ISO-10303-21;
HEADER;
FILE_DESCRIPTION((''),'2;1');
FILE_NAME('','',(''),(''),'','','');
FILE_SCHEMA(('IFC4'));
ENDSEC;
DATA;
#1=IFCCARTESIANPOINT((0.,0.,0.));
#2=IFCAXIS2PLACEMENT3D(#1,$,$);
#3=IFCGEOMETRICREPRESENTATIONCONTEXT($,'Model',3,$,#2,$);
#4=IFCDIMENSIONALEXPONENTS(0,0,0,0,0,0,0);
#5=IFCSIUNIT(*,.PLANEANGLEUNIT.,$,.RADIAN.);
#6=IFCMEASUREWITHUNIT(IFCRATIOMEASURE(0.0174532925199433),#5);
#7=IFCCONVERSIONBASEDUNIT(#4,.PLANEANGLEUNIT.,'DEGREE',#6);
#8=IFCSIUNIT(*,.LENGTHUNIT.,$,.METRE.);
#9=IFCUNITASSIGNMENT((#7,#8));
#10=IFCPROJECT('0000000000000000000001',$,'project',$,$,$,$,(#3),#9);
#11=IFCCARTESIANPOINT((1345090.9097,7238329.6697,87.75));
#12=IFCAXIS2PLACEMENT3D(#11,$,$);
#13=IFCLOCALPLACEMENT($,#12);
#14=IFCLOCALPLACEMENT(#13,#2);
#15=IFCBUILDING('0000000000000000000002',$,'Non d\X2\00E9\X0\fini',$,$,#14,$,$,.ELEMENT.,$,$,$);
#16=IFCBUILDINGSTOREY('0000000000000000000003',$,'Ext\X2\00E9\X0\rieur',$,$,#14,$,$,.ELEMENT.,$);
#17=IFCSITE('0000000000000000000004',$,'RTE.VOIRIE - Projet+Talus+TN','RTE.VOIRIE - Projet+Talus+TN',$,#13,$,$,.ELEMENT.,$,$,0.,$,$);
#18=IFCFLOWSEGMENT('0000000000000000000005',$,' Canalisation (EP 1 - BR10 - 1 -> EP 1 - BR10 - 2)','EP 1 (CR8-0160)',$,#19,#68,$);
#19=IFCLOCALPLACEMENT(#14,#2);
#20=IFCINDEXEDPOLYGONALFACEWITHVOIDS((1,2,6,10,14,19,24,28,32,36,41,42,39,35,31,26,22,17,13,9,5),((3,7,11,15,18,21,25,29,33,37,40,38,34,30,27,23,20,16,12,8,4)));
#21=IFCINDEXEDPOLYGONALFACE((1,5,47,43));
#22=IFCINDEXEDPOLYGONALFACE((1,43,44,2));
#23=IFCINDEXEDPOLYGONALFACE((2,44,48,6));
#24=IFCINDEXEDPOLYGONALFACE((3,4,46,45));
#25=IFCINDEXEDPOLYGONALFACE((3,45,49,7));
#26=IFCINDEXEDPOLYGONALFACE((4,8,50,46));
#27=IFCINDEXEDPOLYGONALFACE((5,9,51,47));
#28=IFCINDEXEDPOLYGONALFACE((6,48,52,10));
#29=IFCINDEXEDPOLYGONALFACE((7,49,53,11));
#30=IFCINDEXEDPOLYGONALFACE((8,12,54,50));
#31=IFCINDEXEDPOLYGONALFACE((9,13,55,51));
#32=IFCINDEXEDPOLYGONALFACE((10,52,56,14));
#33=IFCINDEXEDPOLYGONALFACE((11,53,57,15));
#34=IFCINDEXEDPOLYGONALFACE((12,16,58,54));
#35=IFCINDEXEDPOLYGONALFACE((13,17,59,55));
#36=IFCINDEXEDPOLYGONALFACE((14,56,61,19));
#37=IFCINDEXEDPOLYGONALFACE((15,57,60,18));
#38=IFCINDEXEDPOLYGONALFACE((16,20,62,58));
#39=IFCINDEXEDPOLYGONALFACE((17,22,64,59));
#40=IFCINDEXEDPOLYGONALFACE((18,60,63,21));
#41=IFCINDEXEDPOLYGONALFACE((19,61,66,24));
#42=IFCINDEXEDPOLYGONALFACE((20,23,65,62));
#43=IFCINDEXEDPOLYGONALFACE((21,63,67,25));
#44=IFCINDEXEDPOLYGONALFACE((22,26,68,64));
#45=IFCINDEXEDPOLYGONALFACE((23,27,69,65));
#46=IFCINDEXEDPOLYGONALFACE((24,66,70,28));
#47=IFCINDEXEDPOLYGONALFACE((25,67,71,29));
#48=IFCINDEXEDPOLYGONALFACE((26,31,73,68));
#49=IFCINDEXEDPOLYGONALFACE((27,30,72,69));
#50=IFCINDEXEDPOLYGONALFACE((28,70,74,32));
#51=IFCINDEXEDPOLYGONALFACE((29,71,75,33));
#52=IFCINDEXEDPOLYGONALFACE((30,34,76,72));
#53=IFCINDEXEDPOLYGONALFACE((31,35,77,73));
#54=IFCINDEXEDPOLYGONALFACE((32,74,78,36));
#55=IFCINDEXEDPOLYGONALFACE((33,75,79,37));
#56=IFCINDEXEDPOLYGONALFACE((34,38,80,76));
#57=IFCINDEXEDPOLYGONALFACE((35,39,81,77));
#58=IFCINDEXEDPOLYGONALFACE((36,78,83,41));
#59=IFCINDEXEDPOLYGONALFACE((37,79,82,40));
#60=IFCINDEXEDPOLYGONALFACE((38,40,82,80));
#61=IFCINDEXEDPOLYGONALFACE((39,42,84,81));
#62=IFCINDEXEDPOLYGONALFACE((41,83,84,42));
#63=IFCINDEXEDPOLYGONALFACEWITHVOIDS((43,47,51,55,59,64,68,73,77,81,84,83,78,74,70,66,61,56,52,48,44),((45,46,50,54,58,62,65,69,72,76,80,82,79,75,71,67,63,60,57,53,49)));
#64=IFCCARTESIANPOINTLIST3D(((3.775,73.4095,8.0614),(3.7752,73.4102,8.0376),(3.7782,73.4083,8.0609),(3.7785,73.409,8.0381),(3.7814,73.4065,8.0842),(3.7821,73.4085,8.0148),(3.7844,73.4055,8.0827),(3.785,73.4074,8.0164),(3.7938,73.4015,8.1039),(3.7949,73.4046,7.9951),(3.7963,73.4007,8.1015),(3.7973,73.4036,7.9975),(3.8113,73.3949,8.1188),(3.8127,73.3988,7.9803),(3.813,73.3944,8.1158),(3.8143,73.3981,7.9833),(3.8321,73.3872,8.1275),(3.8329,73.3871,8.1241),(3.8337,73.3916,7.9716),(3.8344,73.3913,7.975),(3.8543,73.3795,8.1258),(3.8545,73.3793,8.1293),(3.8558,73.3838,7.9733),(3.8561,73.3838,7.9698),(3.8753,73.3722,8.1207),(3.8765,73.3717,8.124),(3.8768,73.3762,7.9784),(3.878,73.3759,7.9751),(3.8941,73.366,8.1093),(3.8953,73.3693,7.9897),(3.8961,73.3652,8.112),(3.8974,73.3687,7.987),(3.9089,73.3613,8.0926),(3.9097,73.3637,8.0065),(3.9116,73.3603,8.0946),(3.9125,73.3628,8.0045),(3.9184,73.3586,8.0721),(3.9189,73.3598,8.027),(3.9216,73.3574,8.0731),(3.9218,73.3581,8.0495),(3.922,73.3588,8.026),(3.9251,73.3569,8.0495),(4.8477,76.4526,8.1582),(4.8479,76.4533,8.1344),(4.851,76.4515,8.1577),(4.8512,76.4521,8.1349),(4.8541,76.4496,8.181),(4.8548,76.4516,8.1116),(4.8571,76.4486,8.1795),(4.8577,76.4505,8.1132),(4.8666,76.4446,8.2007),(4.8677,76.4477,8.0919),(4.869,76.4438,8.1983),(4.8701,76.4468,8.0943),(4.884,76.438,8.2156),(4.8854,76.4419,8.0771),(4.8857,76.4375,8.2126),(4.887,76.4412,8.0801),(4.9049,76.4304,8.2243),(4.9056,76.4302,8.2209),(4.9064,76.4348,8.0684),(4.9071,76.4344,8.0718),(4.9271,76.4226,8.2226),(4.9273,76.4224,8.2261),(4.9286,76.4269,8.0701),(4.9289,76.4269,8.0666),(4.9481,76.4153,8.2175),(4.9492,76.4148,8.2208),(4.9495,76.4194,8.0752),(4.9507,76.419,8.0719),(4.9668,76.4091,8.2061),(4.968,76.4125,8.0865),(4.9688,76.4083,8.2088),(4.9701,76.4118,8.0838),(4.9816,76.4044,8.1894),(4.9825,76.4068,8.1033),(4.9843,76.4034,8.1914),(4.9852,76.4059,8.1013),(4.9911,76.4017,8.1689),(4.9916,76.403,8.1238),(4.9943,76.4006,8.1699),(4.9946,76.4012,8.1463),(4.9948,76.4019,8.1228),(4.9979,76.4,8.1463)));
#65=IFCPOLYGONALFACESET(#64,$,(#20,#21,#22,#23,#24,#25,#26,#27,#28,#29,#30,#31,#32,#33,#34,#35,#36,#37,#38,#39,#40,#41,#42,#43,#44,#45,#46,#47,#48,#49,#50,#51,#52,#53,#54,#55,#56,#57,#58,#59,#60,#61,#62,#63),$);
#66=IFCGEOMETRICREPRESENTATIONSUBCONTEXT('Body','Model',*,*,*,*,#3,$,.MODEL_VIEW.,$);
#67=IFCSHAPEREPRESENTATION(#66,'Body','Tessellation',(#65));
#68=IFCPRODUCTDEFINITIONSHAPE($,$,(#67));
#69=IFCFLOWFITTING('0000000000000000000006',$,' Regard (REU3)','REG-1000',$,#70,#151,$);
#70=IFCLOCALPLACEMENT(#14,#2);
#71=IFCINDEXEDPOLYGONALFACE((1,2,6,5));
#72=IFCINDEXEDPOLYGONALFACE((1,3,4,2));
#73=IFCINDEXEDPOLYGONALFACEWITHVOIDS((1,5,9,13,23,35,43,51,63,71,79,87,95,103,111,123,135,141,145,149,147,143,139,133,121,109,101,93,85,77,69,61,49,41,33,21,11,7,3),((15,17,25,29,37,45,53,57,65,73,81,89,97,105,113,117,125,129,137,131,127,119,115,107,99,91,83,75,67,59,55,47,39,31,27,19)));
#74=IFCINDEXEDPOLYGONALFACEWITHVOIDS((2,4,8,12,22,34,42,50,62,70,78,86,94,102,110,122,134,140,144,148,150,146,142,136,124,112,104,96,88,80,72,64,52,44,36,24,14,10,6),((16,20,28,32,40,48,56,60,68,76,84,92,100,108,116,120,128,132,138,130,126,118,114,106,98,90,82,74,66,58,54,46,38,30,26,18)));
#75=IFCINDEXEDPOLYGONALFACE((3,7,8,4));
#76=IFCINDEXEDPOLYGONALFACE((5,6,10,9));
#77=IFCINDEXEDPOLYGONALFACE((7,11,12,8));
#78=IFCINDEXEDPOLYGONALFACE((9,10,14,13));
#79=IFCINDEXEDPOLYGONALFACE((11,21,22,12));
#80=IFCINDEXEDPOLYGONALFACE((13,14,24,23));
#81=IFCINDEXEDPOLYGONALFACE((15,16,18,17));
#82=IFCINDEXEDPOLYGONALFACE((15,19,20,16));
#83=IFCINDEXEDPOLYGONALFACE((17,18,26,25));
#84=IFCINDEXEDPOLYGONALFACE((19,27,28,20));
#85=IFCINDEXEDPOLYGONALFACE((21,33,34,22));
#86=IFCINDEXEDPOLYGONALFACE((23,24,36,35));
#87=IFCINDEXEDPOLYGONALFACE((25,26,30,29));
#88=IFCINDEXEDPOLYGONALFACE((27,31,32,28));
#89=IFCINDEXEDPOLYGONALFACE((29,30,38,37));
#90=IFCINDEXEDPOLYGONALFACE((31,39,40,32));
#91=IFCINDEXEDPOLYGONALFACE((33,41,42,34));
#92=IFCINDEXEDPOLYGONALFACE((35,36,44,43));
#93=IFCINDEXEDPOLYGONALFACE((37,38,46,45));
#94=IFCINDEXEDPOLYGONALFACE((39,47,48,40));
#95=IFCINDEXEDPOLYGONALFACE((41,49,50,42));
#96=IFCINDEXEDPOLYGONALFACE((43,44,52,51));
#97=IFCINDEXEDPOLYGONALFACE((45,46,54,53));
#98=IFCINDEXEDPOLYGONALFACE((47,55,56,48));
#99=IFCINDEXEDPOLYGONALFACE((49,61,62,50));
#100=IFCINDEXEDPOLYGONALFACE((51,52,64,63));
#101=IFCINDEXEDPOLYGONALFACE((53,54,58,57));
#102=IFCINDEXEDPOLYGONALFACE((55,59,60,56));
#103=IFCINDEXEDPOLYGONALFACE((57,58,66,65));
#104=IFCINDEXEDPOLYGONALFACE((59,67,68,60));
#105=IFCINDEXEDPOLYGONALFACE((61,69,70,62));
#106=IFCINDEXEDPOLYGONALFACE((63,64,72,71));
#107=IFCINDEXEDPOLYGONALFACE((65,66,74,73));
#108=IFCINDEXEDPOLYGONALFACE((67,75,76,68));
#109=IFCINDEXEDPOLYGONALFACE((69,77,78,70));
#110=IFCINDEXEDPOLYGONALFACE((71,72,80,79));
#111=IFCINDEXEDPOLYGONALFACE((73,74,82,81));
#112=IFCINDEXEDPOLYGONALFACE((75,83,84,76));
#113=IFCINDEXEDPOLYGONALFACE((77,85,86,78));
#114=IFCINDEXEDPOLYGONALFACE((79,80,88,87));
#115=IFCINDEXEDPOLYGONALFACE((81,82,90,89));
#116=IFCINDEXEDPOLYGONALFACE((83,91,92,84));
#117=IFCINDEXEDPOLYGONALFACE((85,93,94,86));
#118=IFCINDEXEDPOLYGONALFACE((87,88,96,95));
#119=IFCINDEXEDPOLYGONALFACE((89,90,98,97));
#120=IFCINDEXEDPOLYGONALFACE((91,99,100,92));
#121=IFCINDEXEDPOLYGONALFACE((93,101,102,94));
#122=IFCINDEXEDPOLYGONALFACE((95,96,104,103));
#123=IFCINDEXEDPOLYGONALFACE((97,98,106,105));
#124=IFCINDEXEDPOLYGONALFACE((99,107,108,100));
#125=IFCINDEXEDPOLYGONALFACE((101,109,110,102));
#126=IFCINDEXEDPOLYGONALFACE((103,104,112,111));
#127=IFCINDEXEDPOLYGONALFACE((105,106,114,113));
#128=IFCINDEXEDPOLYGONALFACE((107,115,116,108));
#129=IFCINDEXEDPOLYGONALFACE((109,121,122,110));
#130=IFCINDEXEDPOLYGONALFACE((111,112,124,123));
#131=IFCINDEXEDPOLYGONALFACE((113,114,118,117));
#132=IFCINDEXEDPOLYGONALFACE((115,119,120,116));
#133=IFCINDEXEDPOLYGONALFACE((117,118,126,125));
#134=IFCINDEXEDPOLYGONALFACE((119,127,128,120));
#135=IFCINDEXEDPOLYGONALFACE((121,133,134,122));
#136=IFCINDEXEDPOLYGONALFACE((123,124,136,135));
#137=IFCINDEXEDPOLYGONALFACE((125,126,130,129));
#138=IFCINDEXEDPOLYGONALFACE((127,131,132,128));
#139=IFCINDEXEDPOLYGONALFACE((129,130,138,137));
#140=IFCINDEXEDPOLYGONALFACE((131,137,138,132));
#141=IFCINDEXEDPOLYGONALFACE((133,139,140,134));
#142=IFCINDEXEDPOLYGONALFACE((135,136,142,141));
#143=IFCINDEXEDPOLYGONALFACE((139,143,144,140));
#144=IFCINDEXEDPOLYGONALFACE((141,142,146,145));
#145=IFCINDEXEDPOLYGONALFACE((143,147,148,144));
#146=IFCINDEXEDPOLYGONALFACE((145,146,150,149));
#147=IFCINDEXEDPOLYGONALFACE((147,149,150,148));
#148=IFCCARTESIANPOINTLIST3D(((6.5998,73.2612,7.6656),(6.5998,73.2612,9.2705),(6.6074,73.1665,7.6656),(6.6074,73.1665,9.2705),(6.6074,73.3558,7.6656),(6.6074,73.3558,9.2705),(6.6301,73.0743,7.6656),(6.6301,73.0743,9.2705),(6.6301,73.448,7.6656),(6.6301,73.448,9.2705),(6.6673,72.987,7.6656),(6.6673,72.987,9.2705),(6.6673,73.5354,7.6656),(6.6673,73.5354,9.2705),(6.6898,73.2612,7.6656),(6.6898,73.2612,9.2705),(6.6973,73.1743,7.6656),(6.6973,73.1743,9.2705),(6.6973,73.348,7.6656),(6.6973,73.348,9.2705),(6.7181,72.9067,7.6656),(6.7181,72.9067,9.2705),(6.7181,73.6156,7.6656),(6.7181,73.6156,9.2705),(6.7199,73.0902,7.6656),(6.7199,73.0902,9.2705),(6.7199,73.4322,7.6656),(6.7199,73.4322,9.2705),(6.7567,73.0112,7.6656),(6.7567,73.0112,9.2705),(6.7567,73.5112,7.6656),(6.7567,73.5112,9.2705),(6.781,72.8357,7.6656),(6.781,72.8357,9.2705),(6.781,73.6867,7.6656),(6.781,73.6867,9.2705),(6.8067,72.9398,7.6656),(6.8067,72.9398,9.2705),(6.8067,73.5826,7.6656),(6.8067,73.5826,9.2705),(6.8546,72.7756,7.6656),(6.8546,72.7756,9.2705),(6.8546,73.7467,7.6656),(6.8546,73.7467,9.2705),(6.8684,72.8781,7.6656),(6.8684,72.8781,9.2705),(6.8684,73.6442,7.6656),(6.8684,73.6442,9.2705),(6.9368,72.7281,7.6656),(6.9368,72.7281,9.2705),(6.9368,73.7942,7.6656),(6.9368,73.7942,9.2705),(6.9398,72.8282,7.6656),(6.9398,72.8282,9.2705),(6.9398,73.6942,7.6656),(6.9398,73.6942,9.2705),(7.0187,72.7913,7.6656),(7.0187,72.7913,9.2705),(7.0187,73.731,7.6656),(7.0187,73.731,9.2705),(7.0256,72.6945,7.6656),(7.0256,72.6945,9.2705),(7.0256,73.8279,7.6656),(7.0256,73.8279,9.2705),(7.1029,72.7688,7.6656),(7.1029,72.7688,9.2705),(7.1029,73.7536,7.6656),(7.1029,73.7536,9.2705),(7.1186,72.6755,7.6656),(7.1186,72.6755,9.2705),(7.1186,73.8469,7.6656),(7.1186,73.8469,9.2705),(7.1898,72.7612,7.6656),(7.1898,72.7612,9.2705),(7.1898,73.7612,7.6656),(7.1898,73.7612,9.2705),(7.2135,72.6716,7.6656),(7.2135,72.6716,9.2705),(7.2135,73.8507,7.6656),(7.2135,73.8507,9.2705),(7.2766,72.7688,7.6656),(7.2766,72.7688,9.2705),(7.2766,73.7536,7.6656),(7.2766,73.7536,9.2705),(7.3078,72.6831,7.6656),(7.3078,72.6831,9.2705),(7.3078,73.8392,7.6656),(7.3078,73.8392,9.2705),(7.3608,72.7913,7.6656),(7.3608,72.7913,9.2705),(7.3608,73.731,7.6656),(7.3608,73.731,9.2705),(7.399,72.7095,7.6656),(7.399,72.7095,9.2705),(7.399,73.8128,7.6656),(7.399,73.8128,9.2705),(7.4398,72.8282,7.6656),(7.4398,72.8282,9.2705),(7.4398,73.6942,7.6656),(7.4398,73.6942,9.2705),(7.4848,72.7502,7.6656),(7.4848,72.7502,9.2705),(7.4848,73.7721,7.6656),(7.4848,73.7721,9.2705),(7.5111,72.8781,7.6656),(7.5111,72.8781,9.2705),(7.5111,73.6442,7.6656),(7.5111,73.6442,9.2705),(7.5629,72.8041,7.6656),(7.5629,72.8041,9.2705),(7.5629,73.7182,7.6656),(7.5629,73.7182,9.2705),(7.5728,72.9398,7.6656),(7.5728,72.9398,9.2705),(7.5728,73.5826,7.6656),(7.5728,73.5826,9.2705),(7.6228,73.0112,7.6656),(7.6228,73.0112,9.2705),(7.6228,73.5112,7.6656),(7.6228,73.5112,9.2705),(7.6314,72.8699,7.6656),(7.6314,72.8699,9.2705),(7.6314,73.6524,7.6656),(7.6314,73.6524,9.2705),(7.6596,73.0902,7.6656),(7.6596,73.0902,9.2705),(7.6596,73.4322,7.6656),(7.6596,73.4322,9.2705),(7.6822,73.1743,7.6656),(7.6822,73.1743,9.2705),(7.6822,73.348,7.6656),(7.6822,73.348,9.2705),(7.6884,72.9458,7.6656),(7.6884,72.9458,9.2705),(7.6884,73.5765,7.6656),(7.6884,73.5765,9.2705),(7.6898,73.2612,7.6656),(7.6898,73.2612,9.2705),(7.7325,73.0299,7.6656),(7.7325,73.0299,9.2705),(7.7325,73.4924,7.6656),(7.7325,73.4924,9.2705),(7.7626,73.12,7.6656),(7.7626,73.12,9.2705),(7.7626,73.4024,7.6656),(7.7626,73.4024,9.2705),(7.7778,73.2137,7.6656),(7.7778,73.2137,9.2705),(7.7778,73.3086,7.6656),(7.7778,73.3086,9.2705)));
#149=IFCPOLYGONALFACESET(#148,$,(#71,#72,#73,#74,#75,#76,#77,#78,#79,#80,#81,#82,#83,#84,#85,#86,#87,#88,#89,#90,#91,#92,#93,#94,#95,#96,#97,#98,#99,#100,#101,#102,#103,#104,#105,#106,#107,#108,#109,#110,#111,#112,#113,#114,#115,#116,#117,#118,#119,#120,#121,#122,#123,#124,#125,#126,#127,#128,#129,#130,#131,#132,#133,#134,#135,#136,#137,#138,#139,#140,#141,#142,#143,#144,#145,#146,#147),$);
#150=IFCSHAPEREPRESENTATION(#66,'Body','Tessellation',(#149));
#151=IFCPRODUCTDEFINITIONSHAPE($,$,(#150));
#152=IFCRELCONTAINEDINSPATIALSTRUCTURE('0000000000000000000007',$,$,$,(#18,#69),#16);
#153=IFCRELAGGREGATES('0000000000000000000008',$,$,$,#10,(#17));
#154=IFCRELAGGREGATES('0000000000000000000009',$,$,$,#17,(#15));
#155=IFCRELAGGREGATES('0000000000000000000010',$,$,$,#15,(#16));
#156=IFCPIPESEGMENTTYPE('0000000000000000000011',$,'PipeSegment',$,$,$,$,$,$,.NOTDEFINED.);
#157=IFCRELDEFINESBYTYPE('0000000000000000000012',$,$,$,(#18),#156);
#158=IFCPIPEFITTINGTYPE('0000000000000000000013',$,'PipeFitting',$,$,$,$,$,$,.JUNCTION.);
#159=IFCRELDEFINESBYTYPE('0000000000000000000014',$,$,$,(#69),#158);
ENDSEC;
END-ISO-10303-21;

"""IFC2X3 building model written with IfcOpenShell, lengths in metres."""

from ifc_helpers import new_model, entity, si_unit, converted_unit, frame, origin, origin_2d_with_axis, place, context, subcontext, project, spatial, hollow_circle, extrude, type_object, element, save


model = new_model("IFC2X3")

# Units and contexts
model_context = context("Model", 3, world=origin())
body_context = subcontext(model_context, "Body", "Model", "MODEL_VIEW")
ifc_project = project(units=[converted_unit("PLANEANGLEUNIT", "DEGREE", entity("IfcRatioMeasure", 0.0174532925199433), si_unit("PLANEANGLEUNIT", "RADIAN"), dimensions=[0, 0, 0, 0, 0, 0, 0]), si_unit("LENGTHUNIT", "METRE")], contexts=[model_context])

# Site, building, storey
site_placement = place(None, frame((1345090.9097, 7238329.6697, 87.75)))
site = spatial("IfcSite", under=ifc_project, at=site_placement, Name="RTE.VOIRIE - Projet+Talus+TN", Description="RTE.VOIRIE - Projet+Talus+TN", CompositionType="ELEMENT", RefElevation=0.0)
placement = place(site_placement, origin())
building = spatial("IfcBuilding", under=site, at=placement, Name="Non défini", CompositionType="ELEMENT")
storey = spatial("IfcBuildingStorey", under=building, at=placement, Name="Extérieur", CompositionType="ELEMENT")

# Flow segment
pipe_segment_type_1 = type_object("IfcPipeSegmentType", Name="PipeSegment", PredefinedType="NOTDEFINED")
flow_segment_1_placement = place(placement, origin())
element("IfcFlowSegment", 1, at=flow_segment_1_placement, inside=storey, type_object=pipe_segment_type_1, Name=" Canalisation (EP 1 - BR10 - 1 -> EP 1 - BR10 - 2)", Description="EP 1 (CR8-0160)", context=body_context, shape_type="SweptSolid", body=[
    extrude(hollow_circle(Radius=0.08, WallThickness=0.0035, at=origin_2d_with_axis()), frame((4.9224, 76.4266, 8.1463), z_axis=(-0.332309, -0.942694, -0.029987), x_axis=(0.942694, -0.332309, 0.0)), (0.0, 0.0, 1.0), 3.2281),
])

# Flow fitting
pipe_fitting_type_1 = type_object("IfcPipeFittingType", Name="PipeFitting", PredefinedType="JUNCTION")
flow_fitting_1_placement = place(placement, origin())
element("IfcFlowFitting", 2, at=flow_fitting_1_placement, inside=storey, type_object=pipe_fitting_type_1, Name=" Regard (REU3)", Description="REG-1000", context=body_context, shape_type="SweptSolid", body=[
    extrude(hollow_circle(Radius=0.59, WallThickness=0.09, at=origin_2d_with_axis()), frame((7.1898, 73.2612, 7.6656), z_axis=(0.0, 0.0, 1.0), x_axis=(-1.0, 0.0, 0.0)), (0.0, 0.0, 1.0), 1.6049),
])

save(model, "model.ifc")
